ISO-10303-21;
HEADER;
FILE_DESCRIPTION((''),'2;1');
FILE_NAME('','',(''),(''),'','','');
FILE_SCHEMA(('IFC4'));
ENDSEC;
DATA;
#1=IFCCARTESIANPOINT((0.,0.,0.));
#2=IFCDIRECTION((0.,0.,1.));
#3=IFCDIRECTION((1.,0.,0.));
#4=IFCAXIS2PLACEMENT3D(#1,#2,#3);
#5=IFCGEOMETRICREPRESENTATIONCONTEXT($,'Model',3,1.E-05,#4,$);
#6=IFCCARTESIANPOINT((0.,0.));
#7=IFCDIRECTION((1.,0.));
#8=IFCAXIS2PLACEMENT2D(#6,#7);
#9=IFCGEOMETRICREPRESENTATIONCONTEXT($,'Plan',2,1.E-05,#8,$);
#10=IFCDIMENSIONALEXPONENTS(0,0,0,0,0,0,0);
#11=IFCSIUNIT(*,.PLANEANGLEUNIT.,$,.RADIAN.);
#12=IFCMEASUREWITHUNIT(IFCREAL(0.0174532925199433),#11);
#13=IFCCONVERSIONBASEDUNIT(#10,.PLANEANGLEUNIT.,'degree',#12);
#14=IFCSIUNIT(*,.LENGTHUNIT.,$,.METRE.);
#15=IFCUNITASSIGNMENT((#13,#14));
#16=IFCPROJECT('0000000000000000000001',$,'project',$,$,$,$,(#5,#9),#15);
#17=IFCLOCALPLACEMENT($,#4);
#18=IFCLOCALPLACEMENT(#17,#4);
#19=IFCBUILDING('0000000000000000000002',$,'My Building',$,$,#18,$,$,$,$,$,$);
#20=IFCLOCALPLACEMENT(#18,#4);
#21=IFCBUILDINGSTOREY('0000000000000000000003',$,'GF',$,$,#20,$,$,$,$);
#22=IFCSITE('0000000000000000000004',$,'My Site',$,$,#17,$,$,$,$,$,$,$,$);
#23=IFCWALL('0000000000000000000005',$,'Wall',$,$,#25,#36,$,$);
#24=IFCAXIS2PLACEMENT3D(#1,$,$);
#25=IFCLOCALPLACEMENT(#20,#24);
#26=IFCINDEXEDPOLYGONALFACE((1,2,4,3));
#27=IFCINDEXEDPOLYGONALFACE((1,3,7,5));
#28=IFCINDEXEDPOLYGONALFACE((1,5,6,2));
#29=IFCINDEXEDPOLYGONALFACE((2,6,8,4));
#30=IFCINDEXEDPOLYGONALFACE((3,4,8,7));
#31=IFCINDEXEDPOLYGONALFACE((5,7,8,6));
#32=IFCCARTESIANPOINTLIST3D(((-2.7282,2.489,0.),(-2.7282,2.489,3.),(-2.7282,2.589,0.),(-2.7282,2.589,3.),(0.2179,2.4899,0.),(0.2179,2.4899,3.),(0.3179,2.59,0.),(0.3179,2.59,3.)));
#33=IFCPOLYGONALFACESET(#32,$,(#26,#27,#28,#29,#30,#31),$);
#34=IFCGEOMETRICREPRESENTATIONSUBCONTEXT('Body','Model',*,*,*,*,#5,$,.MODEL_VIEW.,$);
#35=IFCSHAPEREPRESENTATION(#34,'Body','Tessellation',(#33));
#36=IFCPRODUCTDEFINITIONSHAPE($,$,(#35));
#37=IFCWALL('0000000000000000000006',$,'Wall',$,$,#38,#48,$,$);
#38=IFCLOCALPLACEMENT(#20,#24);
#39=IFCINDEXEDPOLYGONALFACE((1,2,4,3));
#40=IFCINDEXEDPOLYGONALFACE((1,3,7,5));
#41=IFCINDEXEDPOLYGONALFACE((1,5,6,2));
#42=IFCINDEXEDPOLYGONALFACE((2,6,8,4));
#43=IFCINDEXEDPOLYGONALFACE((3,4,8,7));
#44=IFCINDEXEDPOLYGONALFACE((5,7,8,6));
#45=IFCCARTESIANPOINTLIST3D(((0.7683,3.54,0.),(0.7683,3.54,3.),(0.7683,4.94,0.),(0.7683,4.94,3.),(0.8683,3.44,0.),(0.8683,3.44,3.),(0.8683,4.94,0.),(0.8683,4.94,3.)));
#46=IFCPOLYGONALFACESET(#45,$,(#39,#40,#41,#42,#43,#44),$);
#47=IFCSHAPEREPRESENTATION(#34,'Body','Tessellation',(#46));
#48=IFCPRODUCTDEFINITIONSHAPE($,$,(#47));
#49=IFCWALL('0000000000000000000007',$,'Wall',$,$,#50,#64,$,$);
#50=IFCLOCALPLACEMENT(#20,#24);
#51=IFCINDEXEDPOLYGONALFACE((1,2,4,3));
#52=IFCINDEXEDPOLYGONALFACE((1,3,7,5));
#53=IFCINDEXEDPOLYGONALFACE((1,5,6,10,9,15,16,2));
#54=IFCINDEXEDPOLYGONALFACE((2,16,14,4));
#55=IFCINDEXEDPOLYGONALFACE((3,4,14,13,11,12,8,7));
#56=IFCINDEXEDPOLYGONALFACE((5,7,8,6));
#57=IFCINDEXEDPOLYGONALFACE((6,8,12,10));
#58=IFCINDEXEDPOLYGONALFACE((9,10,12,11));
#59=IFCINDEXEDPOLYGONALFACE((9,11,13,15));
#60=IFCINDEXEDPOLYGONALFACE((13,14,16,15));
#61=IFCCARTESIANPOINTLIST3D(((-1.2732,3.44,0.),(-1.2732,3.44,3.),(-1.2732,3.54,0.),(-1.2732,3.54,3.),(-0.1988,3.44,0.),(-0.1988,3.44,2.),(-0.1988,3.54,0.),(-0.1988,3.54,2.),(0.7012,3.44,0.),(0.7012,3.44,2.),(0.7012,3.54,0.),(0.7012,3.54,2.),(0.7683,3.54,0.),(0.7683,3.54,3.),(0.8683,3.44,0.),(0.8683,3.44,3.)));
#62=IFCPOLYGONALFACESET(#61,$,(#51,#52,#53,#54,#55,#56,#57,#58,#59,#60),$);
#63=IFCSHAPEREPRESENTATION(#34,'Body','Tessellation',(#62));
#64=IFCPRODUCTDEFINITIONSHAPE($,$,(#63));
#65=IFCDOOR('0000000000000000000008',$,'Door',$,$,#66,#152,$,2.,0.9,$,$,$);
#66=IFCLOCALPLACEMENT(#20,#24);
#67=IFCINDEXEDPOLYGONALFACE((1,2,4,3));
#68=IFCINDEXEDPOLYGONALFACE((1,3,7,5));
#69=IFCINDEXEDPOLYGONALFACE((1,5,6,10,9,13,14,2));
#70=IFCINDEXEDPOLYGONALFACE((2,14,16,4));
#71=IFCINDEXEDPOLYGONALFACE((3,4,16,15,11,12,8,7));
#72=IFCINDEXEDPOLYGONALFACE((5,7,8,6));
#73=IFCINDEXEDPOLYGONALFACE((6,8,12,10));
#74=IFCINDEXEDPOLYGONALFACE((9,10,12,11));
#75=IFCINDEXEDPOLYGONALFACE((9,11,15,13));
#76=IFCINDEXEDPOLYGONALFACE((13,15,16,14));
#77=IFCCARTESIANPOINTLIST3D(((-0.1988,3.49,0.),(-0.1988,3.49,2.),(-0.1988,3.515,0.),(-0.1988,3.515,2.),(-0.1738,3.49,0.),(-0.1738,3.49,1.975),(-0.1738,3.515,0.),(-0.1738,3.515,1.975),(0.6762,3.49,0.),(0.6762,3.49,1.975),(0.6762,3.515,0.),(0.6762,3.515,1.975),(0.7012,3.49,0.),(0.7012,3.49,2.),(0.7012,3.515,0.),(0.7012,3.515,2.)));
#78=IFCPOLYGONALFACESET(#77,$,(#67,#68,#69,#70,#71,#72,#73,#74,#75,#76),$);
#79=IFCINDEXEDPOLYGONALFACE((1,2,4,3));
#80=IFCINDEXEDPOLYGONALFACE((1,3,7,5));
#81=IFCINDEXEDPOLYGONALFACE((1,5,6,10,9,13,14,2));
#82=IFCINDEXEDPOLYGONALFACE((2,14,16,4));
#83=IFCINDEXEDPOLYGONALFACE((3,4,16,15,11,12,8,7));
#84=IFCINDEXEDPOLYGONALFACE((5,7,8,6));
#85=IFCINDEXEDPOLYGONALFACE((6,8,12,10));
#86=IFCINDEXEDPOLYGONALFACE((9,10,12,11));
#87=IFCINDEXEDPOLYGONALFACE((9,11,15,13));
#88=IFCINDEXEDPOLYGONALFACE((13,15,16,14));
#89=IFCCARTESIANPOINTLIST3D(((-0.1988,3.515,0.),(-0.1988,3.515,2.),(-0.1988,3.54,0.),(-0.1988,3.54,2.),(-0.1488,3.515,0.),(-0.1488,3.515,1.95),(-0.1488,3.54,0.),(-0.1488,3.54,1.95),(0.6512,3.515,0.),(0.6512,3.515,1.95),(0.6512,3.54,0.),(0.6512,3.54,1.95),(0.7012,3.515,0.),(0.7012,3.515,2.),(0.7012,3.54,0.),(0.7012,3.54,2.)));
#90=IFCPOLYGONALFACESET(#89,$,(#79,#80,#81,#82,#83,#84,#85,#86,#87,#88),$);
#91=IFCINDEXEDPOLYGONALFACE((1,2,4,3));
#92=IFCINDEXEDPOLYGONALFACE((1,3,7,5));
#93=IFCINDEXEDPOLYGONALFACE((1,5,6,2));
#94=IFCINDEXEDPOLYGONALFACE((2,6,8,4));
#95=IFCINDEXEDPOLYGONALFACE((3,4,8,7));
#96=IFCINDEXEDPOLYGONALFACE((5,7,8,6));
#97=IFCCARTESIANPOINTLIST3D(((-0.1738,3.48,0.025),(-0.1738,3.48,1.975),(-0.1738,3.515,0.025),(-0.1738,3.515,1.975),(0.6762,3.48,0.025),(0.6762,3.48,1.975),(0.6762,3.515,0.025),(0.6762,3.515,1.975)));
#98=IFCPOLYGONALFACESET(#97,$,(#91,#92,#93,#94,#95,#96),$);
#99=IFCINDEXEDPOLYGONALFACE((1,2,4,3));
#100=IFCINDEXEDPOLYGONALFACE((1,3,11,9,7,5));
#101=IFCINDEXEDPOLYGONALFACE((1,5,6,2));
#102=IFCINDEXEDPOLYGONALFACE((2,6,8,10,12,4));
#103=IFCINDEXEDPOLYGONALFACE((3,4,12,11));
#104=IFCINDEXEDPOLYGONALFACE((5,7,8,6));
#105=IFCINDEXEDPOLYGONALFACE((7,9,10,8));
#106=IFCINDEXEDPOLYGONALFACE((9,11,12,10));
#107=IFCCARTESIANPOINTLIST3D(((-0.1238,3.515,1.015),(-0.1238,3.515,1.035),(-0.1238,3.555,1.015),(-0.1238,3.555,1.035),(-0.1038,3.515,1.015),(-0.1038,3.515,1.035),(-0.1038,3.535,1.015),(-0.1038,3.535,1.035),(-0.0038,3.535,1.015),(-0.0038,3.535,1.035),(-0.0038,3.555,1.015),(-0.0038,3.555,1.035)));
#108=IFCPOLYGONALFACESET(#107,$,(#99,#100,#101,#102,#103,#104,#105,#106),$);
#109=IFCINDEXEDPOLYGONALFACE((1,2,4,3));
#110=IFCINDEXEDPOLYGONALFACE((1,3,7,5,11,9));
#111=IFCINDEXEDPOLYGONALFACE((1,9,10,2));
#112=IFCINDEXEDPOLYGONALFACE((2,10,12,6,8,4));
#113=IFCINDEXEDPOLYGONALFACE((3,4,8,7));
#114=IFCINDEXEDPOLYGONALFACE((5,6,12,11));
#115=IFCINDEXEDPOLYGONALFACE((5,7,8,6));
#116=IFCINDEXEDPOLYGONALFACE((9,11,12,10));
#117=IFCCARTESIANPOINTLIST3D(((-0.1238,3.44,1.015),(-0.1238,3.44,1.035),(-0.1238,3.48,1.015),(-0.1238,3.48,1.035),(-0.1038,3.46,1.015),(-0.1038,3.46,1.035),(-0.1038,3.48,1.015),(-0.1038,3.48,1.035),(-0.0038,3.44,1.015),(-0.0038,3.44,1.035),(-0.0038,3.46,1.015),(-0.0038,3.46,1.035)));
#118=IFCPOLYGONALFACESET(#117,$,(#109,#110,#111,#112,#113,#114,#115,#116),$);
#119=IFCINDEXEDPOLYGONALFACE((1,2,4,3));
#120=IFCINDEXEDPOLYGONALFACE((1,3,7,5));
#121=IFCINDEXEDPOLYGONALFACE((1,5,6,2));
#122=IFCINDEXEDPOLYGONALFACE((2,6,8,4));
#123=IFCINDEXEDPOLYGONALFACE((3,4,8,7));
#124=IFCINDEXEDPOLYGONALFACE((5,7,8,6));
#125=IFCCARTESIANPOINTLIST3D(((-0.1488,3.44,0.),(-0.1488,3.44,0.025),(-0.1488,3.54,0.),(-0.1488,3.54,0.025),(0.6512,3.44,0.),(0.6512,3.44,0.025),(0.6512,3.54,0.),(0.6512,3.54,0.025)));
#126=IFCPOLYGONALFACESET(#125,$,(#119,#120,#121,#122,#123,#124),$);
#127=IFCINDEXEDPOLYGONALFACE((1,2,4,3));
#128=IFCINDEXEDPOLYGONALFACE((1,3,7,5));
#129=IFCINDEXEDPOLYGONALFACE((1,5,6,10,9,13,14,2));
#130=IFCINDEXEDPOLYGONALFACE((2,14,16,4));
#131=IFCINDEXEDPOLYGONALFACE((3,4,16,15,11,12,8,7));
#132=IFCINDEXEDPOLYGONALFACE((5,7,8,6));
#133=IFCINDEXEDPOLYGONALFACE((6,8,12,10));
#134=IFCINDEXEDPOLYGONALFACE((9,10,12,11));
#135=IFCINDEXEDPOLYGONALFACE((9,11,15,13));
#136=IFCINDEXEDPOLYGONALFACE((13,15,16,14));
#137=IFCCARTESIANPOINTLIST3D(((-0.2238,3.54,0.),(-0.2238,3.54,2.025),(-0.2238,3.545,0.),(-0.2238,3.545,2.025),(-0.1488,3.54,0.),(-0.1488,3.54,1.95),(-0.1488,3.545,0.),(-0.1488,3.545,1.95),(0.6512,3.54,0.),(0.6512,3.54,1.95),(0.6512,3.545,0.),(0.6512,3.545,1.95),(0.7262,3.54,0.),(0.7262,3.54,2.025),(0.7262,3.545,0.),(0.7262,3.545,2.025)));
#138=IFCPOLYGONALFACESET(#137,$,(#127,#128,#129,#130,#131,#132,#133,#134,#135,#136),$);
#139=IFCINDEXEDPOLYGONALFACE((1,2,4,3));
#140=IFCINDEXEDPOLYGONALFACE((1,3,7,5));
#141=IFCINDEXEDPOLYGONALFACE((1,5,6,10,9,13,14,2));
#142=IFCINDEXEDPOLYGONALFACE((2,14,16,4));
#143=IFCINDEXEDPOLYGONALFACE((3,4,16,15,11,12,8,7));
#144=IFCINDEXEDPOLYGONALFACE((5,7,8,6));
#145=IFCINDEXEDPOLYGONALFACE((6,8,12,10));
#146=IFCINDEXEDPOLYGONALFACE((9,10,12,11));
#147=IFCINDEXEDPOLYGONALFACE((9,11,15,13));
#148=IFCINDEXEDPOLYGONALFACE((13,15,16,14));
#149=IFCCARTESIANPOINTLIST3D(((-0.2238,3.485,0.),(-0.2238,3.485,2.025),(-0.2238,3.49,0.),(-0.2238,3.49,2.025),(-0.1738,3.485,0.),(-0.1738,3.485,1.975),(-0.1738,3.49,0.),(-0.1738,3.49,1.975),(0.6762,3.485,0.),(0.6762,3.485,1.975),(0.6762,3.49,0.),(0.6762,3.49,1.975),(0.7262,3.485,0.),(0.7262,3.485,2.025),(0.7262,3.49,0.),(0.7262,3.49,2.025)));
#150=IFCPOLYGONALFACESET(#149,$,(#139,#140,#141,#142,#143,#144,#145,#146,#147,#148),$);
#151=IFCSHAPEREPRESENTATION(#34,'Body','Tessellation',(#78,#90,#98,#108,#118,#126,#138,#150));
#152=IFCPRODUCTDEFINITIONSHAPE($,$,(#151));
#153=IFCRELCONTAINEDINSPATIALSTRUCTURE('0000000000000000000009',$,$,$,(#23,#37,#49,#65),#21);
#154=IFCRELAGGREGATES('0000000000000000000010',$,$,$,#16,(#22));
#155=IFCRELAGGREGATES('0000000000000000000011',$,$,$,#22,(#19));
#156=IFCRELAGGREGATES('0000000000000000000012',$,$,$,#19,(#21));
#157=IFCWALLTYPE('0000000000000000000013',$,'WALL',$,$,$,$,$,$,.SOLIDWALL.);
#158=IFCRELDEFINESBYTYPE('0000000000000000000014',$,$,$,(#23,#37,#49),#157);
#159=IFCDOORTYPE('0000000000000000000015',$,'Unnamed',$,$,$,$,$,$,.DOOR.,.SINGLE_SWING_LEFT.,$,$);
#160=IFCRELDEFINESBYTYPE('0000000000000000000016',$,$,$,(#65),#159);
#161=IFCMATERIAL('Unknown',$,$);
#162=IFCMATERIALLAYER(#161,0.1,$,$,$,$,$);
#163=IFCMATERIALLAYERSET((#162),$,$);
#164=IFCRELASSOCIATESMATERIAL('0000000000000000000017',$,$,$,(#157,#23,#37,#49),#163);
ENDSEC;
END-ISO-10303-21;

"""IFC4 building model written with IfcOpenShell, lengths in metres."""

from ifc_helpers import new_model, entity, si_unit, converted_unit, frame, origin_with_axes, origin_2d_with_axis, place, context, subcontext, project, spatial, line, indexed_curve, outline, extrude, shape, source, transform, mapped, material, layer, layer_set, layer_usage, type_object, type_shapes, element, fill, save


model = new_model("IFC4")

# Units and contexts
model_context = context("Model", 3, precision=1e-05, world=origin_with_axes())
plan_context = context("Plan", 2, precision=1e-05, world=origin_2d_with_axis())
body_context_1 = subcontext(model_context, "Body", "Model", "MODEL_VIEW")
body_context_2 = subcontext(plan_context, "Body", "Plan", "PLAN_VIEW")
ifc_project = project(units=[converted_unit("PLANEANGLEUNIT", "degree", entity("IfcReal", 0.0174532925199433), si_unit("PLANEANGLEUNIT", "RADIAN"), dimensions=[0, 0, 0, 0, 0, 0, 0]), si_unit("LENGTHUNIT", "METRE")], contexts=[model_context, plan_context])

# Site, building, storey
site_placement = place(None, origin_with_axes())
site = spatial("IfcSite", under=ifc_project, at=site_placement, Name="My Site")
building_placement = place(site_placement, origin_with_axes())
building = spatial("IfcBuilding", under=site, at=building_placement, Name="My Building")
storey_placement = place(building_placement, origin_with_axes())
storey = spatial("IfcBuildingStorey", under=building, at=storey_placement, Name="GF")

# Shared definitions
ifc_material = material(Name="Unknown")

# Shared definitions
ifc_layer_1 = layer(ifc_material, 0.1)
ifc_layer_set_1 = layer_set([ifc_layer_1])
wall_type = type_object("IfcWallType", Name="WALL", PredefinedType="SOLIDWALL", material=ifc_layer_set_1)
shared_shape_1 = source(origin_with_axes(), body_context_1, "Body", "SweptSolid", [
    extrude(outline(indexed_curve([(0.0, 0.0), (0.9, 0.0), (0.9, 2.0), (0.0, 2.0)], segments=[line(1, 2, 3, 4, 1)])), frame((0.0, -0.6, 0.0), z_axis=(0.0, -1.0, 0.0), x_axis=(1.0, 0.0, 0.0)), (0.0, 0.0, -1.0), 1.2),
])
door_type = type_object("IfcDoorType", Name="Unnamed", OperationType="SINGLE_SWING_LEFT", PredefinedType="DOOR")
shared_shape_2 = source(origin_with_axes(), body_context_1, "Body", "SweptSolid", [
    extrude(outline(indexed_curve([(0.0, 0.0), (0.0, 2.0), (0.9, 2.0), (0.9, 0.0), (0.875, 0.0), (0.875, 1.975), (0.025, 1.975), (0.025, 0.0)], segments=[line(1, 2, 3, 4, 5, 6, 7, 8, 1)])), frame((0.0, 0.025, 0.0), z_axis=(0.0, -1.0, 0.0), x_axis=(1.0, 0.0, 0.0)), (0.0, 0.0, -1.0), 0.025),
    extrude(outline(indexed_curve([(0.0, 0.0), (0.0, 2.0), (0.9, 2.0), (0.9, 0.0), (0.85, 0.0), (0.85, 1.95), (0.05, 1.95), (0.05, 0.0)], segments=[line(1, 2, 3, 4, 5, 6, 7, 8, 1)])), frame((0.0, 0.0, 0.0), z_axis=(0.0, -1.0, 0.0), x_axis=(1.0, 0.0, 0.0)), (0.0, 0.0, -1.0), 0.025),
    extrude(outline(indexed_curve([(0.0, 0.0), (0.85, 0.0), (0.85, 0.035), (0.0, 0.035)], segments=[line(1, 2, 3, 4, 1)])), frame((0.025, 0.025, 0.025), z_axis=(0.0, 0.0, 1.0), x_axis=(1.0, 0.0, 0.0)), (0.0, 0.0, 1.0), 1.95),
    extrude(outline(indexed_curve([(0.0, 0.0), (0.0, -0.04), (-0.12, -0.04), (-0.12, -0.02), (-0.02, -0.02), (-0.02, 0.0)], segments=[line(1, 2, 3, 4, 5, 6, 1)])), frame((0.825, 0.025, 1.015), z_axis=(0.0, 0.0, 1.0), x_axis=(1.0, 0.0, 0.0)), (0.0, 0.0, 1.0), 0.02),
    extrude(outline(indexed_curve([(0.0, 0.0), (0.0, 0.04), (-0.12, 0.04), (-0.12, 0.02), (-0.02, 0.02), (-0.02, 0.0)], segments=[line(1, 2, 3, 4, 5, 6, 1)])), frame((0.825, 0.06, 1.015), z_axis=(0.0, 0.0, 1.0), x_axis=(1.0, 0.0, 0.0)), (0.0, 0.0, 1.0), 0.02),
    extrude(outline(indexed_curve([(0.0, 0.0), (0.8, 0.0), (0.8, 0.1), (0.0, 0.1)], segments=[line(1, 2, 3, 4, 1)])), frame((0.05, 0.0, 0.0), z_axis=(0.0, 0.0, 1.0), x_axis=(1.0, 0.0, 0.0)), (0.0, 0.0, 1.0), 0.025),
    extrude(outline(indexed_curve([(0.0, 0.0), (0.0, 2.025), (0.95, 2.025), (0.95, 0.0), (0.875, 0.0), (0.875, 1.95), (0.075, 1.95), (0.075, 0.0)], segments=[line(1, 2, 3, 4, 5, 6, 7, 8, 1)])), frame((-0.025, -0.005, 0.0), z_axis=(0.0, -1.0, 0.0), x_axis=(1.0, 0.0, 0.0)), (0.0, 0.0, -1.0), 0.005),
    extrude(outline(indexed_curve([(0.0, 0.0), (0.0, 2.025), (0.95, 2.025), (0.95, 0.0), (0.9, 0.0), (0.9, 1.975), (0.05, 1.975), (0.05, 0.0)], segments=[line(1, 2, 3, 4, 5, 6, 7, 8, 1)])), frame((-0.025, 0.05, 0.0), z_axis=(0.0, -1.0, 0.0), x_axis=(1.0, 0.0, 0.0)), (0.0, 0.0, -1.0), 0.005),
])
shared_shape_3 = source(origin_with_axes(), body_context_2, "Body", "Curve2D", [
    entity("IfcIndexedPolyCurve", entity("IfcCartesianPointList2D", [[0.0, 0.0], [0.0, 0.05], [0.025, 0.05], [0.025, 0.025], [0.05, 0.025], [0.05, 0.0]]), [entity("IfcLineIndex", [1, 2, 3, 4, 5, 6, 1])]),
    entity("IfcIndexedPolyCurve", entity("IfcCartesianPointList2D", [[0.9, 0.0], [0.9, 0.05], [0.875, 0.05], [0.875, 0.025], [0.85, 0.025], [0.85, 0.0]]), [entity("IfcLineIndex", [1, 2, 3, 4, 5, 6, 1])]),
    entity("IfcTrimmedCurve", entity("IfcEllipse", entity("IfcAxis2Placement2D", entity("IfcCartesianPoint", [0.06, 0.05]), entity("IfcDirection", [1.0, 0.0])), 0.815, 0.85), [entity("IfcCartesianPoint", [0.875, 0.05])], [entity("IfcCartesianPoint", [0.06, 0.9])], True, "CARTESIAN"),
    entity("IfcIndexedPolyCurve", entity("IfcCartesianPointList2D", [[0.025, 0.05], [0.06, 0.05], [0.06, 0.9], [0.025, 0.9]]), [entity("IfcLineIndex", [1, 2, 3, 4, 1])]),
])
type_shapes(door_type, [shared_shape_2, shared_shape_3])

# Wall
ifc_layer_usage_1 = layer_usage(ifc_layer_set_1, "AXIS2", "POSITIVE", 0.0)
wall_1_placement = place(storey_placement, frame((0.3179, 2.59, 0.0), z_axis=(0.0, 0.0, 1.0), x_axis=(-1.0, -0.000321, 0.0)))
element("IfcWall", 1, at=wall_1_placement, inside=storey, type_object=wall_type, material=ifc_layer_usage_1, Name="Wall", context=body_context_1, shape_type="SweptSolid", body=[
    extrude(outline(indexed_curve([(0.0, 0.0), (0.1, 0.1), (3.0462, 0.1), (3.0462, 0.0)], segments=[line(1, 2, 3, 4, 1)])), origin_with_axes(), (0.0, 0.0, 1.0), 3.0),
])

# Wall
ifc_layer_usage_2 = layer_usage(ifc_layer_set_1, "AXIS2", "POSITIVE", 0.0)
wall_2_placement = place(storey_placement, frame((0.7683, 4.94, 0.0), z_axis=(0.0, 0.0, 1.0), x_axis=(0.0, -1.0, 0.0)))
element("IfcWall", 2, at=wall_2_placement, inside=storey, type_object=wall_type, material=ifc_layer_usage_2, Name="Wall", context=body_context_1, shape_type="SweptSolid", body=[
    extrude(outline(indexed_curve([(0.0, 0.0), (0.0, 0.1), (1.5, 0.1), (1.4, 0.0)], segments=[line(1, 2, 3, 4, 1)])), origin_with_axes(), (0.0, 0.0, 1.0), 3.0),
])

# Wall, opening, door
ifc_layer_usage_3 = layer_usage(ifc_layer_set_1, "AXIS2", "POSITIVE", 0.0)
wall_3_placement = place(storey_placement, frame((0.7683, 3.54, 0.0), z_axis=(0.0, 0.0, 1.0), x_axis=(-1.0, 0.0, 0.0)))
wall_3 = element("IfcWall", 3, at=wall_3_placement, inside=storey, type_object=wall_type, material=ifc_layer_usage_3, Name="Wall", context=body_context_1, shape_type="SweptSolid", body=[
    extrude(outline(indexed_curve([(0.0, 0.0), (-0.1, 0.1), (2.0415, 0.1), (2.0415, 0.0)], segments=[line(1, 2, 3, 4, 1)])), origin_with_axes(), (0.0, 0.0, 1.0), 3.0),
])
opening_1_placement = place(wall_3_placement, frame((0.0671, 0.0, 0.0), z_axis=(0.0, 0.0, 1.0), x_axis=(1.0, 0.0, 0.0)))
opening_1 = element("IfcOpeningElement", 4, at=opening_1_placement, cuts=wall_3, PredefinedType="OPENING", context=body_context_1, shape_type="MappedRepresentation", body=[
    mapped(shared_shape_1, transform((0.0, 0.0, 0.0), x_axis=(1.0, 0.0, 0.0), y_axis=(0.0, 1.0, 0.0), z_axis=(0.0, 0.0, 1.0), scale=1.0)),
])
door_1_placement = place(opening_1_placement, frame((0.0, 0.0, 0.0), z_axis=(0.0, 0.0, 1.0), x_axis=(1.0, 0.0, 0.0)))
door_1 = element("IfcDoor", 5, at=door_1_placement, inside=storey, type_object=door_type, Name="Door", OverallHeight=2.0, OverallWidth=0.9, shapes=[
    shape(body_context_1, "Body", "MappedRepresentation", [mapped(shared_shape_2, transform((0.0, 0.0, 0.0), x_axis=(1.0, 0.0, 0.0), y_axis=(0.0, 1.0, 0.0), z_axis=(0.0, 0.0, 1.0), scale=1.0))]),
    shape(body_context_2, "Body", "MappedRepresentation", [mapped(shared_shape_3, transform((0.0, 0.0, 0.0), x_axis=(1.0, 0.0, 0.0), y_axis=(0.0, 1.0, 0.0), z_axis=(0.0, 0.0, 1.0), scale=1.0))]),
])
fill(opening_1, door_1)

save(model, "model.ifc")
